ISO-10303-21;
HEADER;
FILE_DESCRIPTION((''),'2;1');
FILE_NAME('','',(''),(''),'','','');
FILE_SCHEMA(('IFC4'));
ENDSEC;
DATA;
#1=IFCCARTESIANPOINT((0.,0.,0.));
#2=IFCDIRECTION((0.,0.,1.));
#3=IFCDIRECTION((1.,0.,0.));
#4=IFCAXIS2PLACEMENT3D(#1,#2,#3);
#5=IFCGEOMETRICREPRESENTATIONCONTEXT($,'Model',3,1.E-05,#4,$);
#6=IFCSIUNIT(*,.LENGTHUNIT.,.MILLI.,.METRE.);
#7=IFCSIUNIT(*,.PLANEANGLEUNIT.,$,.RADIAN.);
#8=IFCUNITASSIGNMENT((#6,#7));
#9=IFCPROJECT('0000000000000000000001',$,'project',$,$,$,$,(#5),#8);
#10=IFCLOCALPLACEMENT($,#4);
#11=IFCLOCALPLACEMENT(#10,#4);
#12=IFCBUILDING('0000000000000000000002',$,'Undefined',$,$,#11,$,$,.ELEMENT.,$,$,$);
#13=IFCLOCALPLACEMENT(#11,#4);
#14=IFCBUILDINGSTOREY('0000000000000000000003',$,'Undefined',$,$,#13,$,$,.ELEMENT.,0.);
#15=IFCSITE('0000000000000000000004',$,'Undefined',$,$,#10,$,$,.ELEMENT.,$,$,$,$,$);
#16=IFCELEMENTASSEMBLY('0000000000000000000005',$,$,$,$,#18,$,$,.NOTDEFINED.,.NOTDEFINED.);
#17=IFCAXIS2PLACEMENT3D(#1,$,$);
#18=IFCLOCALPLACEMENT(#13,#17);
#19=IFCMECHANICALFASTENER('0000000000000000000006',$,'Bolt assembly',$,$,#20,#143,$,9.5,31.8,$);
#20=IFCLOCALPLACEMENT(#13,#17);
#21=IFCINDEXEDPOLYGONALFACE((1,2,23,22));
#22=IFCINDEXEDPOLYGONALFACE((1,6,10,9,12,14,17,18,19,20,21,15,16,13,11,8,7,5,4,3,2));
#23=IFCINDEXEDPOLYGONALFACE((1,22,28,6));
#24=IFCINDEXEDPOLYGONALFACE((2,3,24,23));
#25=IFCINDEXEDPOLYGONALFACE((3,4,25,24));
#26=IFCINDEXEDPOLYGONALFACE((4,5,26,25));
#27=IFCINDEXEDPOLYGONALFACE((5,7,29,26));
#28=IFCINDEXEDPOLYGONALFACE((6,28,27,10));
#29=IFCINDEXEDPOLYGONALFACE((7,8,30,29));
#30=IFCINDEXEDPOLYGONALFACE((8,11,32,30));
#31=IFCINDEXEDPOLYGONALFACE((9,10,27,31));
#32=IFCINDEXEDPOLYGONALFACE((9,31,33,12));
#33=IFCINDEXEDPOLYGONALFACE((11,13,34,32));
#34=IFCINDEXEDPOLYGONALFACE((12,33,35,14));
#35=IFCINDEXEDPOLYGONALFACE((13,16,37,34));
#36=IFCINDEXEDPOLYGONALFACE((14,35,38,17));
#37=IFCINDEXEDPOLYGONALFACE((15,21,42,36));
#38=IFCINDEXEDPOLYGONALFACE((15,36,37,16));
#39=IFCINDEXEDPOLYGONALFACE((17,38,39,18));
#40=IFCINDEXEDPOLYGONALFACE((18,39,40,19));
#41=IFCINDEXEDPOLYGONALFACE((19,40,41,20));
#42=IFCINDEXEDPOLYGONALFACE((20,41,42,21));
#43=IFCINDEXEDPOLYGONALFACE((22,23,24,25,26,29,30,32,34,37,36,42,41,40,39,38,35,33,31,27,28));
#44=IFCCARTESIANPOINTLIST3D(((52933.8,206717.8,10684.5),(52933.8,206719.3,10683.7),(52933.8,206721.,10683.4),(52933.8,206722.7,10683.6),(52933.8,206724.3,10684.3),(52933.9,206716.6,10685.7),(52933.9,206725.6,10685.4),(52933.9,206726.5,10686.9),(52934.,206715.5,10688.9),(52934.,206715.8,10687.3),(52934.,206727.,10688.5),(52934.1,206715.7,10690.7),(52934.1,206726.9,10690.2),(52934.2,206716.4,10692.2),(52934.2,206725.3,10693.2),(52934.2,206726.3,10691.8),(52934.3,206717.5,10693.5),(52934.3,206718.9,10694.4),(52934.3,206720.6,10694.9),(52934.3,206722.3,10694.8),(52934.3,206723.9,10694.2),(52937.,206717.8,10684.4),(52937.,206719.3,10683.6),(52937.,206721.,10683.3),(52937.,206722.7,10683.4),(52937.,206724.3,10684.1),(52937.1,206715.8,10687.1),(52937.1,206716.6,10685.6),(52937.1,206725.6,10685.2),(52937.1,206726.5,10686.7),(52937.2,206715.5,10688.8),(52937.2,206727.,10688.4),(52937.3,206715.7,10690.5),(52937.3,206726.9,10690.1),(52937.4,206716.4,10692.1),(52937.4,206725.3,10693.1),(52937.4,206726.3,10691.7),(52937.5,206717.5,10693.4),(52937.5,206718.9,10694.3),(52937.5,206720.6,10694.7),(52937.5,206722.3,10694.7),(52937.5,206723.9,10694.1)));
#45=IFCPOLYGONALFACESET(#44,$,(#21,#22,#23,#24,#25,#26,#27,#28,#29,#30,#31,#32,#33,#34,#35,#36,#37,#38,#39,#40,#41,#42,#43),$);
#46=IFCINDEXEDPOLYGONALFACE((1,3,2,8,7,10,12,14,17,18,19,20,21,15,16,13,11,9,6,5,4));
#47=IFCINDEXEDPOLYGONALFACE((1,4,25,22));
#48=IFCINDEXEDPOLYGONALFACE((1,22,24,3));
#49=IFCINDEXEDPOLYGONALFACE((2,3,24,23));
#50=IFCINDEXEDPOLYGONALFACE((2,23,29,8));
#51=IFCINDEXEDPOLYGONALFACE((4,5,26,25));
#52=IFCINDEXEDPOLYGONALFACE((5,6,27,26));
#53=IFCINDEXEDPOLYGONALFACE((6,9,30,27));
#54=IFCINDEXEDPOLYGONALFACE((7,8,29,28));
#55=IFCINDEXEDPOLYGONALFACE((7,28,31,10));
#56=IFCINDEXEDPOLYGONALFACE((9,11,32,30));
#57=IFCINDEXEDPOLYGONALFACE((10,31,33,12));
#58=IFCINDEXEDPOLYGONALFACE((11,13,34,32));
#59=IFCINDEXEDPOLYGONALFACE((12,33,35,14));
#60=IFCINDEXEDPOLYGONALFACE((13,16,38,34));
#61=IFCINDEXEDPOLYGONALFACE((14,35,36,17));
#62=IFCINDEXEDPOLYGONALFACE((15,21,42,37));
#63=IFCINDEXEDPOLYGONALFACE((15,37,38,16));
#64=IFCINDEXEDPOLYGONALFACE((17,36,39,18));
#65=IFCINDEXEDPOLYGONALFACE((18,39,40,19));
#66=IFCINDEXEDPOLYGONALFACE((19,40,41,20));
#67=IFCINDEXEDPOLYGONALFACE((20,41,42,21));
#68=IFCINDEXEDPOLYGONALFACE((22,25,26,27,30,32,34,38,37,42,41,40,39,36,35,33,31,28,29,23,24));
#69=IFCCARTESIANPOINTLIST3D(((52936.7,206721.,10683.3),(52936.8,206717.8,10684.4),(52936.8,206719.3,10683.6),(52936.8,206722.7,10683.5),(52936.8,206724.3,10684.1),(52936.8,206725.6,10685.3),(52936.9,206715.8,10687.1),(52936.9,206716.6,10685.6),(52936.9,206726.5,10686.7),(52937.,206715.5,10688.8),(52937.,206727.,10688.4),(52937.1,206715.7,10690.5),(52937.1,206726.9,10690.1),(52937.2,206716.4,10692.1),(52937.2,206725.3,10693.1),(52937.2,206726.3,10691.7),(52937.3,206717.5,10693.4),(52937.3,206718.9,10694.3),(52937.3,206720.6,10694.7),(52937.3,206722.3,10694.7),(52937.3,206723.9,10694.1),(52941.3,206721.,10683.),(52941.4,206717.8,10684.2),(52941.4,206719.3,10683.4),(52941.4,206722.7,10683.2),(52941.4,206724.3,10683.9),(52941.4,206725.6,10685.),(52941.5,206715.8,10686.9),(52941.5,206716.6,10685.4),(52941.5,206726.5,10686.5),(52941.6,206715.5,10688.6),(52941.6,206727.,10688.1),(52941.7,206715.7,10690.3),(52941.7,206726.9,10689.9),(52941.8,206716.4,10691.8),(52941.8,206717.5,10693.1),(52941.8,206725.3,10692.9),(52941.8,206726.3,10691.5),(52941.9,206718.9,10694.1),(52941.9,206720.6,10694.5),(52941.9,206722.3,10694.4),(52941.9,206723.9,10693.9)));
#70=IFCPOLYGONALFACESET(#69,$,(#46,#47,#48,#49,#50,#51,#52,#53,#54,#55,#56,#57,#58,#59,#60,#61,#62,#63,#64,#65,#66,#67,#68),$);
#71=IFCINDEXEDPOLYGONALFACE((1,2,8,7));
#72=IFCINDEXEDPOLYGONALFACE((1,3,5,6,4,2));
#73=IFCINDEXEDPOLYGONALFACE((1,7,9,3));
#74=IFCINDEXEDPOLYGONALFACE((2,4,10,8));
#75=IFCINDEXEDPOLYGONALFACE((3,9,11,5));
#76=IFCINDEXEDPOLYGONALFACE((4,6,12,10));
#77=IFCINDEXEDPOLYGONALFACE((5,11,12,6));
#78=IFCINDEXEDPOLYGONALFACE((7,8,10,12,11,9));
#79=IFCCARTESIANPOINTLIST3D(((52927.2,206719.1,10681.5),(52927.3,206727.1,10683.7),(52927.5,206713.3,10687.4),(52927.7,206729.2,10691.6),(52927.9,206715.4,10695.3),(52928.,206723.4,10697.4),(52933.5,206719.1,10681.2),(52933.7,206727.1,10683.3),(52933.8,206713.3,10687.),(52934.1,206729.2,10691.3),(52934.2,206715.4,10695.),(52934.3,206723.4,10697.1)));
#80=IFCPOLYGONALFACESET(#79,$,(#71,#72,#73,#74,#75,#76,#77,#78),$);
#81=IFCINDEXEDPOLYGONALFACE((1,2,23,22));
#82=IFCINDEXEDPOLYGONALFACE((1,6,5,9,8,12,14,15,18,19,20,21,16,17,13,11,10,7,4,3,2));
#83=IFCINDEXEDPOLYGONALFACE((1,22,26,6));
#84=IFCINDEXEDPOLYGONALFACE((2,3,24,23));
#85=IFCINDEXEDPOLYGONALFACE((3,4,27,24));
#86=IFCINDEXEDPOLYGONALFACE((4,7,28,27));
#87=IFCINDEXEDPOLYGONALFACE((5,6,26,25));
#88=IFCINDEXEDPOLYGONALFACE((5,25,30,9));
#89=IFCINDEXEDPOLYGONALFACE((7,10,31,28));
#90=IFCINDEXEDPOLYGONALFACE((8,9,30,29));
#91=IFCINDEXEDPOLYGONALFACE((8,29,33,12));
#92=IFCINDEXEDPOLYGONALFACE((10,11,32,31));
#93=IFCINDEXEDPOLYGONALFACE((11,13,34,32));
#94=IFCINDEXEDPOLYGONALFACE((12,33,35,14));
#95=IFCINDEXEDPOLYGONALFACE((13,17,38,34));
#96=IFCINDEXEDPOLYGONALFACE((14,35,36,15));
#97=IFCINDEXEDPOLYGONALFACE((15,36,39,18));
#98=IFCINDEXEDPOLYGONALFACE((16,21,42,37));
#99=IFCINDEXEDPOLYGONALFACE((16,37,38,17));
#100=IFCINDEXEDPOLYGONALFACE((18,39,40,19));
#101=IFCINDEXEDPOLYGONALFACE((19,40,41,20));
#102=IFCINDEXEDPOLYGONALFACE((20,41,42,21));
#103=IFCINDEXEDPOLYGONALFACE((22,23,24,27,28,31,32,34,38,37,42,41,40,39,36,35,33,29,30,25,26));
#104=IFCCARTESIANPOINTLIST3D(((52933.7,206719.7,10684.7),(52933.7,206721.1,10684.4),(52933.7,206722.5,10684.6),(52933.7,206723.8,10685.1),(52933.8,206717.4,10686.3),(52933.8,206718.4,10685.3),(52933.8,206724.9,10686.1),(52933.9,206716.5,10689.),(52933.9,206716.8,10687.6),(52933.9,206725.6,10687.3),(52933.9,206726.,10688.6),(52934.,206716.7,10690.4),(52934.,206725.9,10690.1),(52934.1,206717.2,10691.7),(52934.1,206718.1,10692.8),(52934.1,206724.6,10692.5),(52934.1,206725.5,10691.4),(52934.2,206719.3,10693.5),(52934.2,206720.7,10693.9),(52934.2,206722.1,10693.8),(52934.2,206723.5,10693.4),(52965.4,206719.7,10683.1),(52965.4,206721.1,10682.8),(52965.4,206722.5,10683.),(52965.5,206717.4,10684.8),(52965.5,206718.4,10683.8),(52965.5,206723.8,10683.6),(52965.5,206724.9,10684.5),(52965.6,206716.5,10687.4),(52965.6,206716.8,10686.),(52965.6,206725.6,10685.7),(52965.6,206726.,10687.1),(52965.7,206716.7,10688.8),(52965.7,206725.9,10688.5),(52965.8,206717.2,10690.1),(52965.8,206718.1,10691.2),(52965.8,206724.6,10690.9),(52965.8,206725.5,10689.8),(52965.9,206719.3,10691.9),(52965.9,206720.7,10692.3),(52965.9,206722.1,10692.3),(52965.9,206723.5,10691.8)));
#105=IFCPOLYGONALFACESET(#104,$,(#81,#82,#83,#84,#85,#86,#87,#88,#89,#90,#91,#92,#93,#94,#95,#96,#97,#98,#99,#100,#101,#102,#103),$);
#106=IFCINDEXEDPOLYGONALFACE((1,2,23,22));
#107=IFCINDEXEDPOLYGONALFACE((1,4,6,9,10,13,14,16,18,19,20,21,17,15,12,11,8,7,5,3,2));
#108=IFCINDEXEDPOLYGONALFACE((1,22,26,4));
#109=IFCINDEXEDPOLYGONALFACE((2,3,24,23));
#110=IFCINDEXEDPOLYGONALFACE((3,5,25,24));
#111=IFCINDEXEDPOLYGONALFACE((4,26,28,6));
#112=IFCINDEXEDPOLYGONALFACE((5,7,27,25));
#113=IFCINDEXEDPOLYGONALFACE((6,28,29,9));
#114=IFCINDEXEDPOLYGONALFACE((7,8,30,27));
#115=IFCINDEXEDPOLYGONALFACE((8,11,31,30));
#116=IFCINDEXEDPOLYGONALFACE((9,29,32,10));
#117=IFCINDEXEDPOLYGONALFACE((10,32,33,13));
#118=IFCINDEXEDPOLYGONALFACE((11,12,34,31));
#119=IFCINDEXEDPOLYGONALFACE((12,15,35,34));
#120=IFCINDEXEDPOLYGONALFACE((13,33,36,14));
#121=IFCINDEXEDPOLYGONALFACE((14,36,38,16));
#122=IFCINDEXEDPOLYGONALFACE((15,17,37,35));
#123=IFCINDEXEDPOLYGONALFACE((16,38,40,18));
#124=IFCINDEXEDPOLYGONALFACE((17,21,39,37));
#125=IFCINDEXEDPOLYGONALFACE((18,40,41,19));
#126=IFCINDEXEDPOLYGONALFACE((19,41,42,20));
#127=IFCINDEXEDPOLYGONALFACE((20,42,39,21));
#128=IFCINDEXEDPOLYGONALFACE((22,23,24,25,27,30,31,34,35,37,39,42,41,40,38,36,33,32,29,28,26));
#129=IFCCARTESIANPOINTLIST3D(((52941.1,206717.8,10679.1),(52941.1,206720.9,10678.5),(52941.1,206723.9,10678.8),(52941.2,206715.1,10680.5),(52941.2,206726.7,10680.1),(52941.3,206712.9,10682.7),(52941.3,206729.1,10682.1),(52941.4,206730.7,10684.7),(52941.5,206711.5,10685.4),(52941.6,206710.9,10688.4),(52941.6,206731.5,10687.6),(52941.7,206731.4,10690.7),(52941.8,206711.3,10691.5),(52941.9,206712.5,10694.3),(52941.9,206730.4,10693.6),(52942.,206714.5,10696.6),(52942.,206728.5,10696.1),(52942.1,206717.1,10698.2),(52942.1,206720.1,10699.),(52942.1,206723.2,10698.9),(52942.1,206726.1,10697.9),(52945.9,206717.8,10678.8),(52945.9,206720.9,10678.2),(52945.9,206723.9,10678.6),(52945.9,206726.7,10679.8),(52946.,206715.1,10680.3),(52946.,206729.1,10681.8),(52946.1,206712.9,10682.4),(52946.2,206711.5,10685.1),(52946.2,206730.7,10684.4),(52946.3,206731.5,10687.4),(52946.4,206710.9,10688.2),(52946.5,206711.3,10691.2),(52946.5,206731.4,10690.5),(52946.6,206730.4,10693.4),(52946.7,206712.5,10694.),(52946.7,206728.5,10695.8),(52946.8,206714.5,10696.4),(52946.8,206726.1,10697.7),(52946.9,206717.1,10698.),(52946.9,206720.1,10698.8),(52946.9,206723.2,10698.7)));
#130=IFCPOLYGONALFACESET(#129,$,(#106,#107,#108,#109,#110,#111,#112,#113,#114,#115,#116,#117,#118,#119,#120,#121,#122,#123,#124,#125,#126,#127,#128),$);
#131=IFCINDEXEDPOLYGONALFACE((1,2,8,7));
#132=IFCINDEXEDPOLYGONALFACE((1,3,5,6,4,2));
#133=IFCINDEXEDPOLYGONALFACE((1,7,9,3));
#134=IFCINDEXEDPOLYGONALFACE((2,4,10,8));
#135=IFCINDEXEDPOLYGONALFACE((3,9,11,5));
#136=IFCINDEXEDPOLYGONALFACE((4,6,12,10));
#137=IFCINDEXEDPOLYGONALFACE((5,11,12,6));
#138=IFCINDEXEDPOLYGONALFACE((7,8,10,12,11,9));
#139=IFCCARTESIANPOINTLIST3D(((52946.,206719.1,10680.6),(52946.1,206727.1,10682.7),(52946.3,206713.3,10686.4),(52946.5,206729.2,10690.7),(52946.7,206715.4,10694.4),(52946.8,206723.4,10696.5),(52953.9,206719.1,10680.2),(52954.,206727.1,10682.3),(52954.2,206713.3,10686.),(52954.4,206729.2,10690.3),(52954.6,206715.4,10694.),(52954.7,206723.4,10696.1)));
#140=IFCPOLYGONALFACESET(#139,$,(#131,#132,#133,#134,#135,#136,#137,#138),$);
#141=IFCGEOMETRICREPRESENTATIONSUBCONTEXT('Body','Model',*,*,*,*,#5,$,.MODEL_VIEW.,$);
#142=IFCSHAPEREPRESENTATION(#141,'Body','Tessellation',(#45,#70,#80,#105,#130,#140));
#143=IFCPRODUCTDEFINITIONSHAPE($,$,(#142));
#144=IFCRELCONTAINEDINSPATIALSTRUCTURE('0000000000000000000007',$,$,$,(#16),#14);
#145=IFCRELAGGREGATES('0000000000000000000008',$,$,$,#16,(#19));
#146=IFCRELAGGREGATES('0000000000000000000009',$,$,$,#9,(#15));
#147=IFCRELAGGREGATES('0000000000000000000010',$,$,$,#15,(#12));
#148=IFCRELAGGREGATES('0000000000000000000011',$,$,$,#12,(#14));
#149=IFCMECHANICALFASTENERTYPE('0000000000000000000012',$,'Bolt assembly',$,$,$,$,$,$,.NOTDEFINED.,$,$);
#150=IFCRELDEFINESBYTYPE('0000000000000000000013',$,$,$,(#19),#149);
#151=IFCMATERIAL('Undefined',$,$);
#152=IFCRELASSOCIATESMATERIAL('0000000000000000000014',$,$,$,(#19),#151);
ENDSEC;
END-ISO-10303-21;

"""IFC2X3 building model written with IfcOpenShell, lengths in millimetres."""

from ifc_helpers import new_model, si_unit, frame, origin_with_axes, origin_2d_with_axis, place, context, subcontext, project, spatial, polyline, circle, outline, extrude, source, transform, mapped, material, type_object, element, aggregate, save


model = new_model("IFC2X3")

# Units and contexts
model_context = context("Model", 3, precision=1e-05, world=origin_with_axes())
body_context = subcontext(model_context, "Body", "Model", "MODEL_VIEW")
ifc_project = project(units=[si_unit("LENGTHUNIT", "METRE", prefix="MILLI"), si_unit("PLANEANGLEUNIT", "RADIAN")], contexts=[model_context])

# Site, building, storey
site_placement = place(None, origin_with_axes())
site = spatial("IfcSite", under=ifc_project, at=site_placement, Name="Undefined", CompositionType="ELEMENT")
building_placement = place(site_placement, origin_with_axes())
building = spatial("IfcBuilding", under=site, at=building_placement, Name="Undefined", CompositionType="ELEMENT")
storey_placement = place(building_placement, origin_with_axes())
storey = spatial("IfcBuildingStorey", under=building, at=storey_placement, Name="Undefined", CompositionType="ELEMENT", Elevation=0.0)

# Element assembly
assembly_1_placement = place(storey_placement, origin_with_axes())
assembly_1 = element("IfcElementAssembly", 1, at=assembly_1_placement, inside=storey, AssemblyPlace="NOTDEFINED", PredefinedType="NOTDEFINED")

# Shared definitions
ifc_material_1 = material(Name="Undefined")
mechanical_fastener_type = type_object("IfcMechanicalFastenerType", Name="Bolt assembly")

# Mechanical fastener
shared_shape_1 = source(origin_with_axes(), body_context, "Body", "SweptSolid", [
    extrude(circle(Radius=5.8, at=origin_2d_with_axis()), frame((0.0, -7.6, 0.0), z_axis=(0.0, 1.0, 0.0), x_axis=(1.0, 0.0, 0.0)), (0.0, 0.0, 1.0), 3.2),
    extrude(circle(Radius=5.8, at=origin_2d_with_axis()), frame((0.0, -4.6, 0.0), z_axis=(0.0, 1.0, 0.0), x_axis=(1.0, 0.0, 0.0)), (0.0, 0.0, 1.0), 4.6),
    extrude(outline(polyline([(7.1, -4.1), (7.1, 4.1), (0.0, 8.2), (-7.1, 4.1), (-7.1, -4.1), (0.0, -8.2), (7.1, -4.1)])), frame((0.0, -14.0, 0.0), z_axis=(0.0, 1.0, 0.0), x_axis=(1.0, 0.0, 0.0)), (0.0, 0.0, 1.0), 6.3),
    extrude(circle(Radius=4.8, at=origin_2d_with_axis()), frame((0.0, -7.7, 0.0), z_axis=(0.0, 1.0, 0.0), x_axis=(1.0, 0.0, 0.0)), (0.0, 0.0, 1.0), 31.8),
    extrude(circle(Radius=10.3, at=origin_2d_with_axis()), frame((0.0, 0.0, 0.0), z_axis=(0.0, 1.0, 0.0), x_axis=(1.0, 0.0, 0.0)), (0.0, 0.0, 1.0), 4.8),
    extrude(outline(polyline([(7.1, -4.1), (7.1, 4.1), (0.0, 8.2), (-7.1, 4.1), (-7.1, -4.1), (0.0, -8.2), (7.1, -4.1)])), frame((0.0, 4.8, 0.0), z_axis=(0.0, 1.0, 0.0), x_axis=(1.0, 0.0, 0.0)), (0.0, 0.0, 1.0), 7.9),
])
mechanical_fastener_1_placement = place(assembly_1_placement, frame((52941.6, 206721.2, 10688.8), z_axis=(-0.035281, 0.707107, -0.706226), x_axis=(0.035282, 0.707107, 0.706226)))
mechanical_fastener_1 = element("IfcMechanicalFastener", 2, at=mechanical_fastener_1_placement, type_object=mechanical_fastener_type, material=ifc_material_1, Name="Bolt assembly", NominalDiameter=9.5, NominalLength=31.8, context=body_context, shape_type="MappedRepresentation", body=[
    mapped(shared_shape_1, transform((0.0, 0.0, 0.0))),
])
aggregate(assembly_1, [mechanical_fastener_1])

save(model, "model.ifc")
